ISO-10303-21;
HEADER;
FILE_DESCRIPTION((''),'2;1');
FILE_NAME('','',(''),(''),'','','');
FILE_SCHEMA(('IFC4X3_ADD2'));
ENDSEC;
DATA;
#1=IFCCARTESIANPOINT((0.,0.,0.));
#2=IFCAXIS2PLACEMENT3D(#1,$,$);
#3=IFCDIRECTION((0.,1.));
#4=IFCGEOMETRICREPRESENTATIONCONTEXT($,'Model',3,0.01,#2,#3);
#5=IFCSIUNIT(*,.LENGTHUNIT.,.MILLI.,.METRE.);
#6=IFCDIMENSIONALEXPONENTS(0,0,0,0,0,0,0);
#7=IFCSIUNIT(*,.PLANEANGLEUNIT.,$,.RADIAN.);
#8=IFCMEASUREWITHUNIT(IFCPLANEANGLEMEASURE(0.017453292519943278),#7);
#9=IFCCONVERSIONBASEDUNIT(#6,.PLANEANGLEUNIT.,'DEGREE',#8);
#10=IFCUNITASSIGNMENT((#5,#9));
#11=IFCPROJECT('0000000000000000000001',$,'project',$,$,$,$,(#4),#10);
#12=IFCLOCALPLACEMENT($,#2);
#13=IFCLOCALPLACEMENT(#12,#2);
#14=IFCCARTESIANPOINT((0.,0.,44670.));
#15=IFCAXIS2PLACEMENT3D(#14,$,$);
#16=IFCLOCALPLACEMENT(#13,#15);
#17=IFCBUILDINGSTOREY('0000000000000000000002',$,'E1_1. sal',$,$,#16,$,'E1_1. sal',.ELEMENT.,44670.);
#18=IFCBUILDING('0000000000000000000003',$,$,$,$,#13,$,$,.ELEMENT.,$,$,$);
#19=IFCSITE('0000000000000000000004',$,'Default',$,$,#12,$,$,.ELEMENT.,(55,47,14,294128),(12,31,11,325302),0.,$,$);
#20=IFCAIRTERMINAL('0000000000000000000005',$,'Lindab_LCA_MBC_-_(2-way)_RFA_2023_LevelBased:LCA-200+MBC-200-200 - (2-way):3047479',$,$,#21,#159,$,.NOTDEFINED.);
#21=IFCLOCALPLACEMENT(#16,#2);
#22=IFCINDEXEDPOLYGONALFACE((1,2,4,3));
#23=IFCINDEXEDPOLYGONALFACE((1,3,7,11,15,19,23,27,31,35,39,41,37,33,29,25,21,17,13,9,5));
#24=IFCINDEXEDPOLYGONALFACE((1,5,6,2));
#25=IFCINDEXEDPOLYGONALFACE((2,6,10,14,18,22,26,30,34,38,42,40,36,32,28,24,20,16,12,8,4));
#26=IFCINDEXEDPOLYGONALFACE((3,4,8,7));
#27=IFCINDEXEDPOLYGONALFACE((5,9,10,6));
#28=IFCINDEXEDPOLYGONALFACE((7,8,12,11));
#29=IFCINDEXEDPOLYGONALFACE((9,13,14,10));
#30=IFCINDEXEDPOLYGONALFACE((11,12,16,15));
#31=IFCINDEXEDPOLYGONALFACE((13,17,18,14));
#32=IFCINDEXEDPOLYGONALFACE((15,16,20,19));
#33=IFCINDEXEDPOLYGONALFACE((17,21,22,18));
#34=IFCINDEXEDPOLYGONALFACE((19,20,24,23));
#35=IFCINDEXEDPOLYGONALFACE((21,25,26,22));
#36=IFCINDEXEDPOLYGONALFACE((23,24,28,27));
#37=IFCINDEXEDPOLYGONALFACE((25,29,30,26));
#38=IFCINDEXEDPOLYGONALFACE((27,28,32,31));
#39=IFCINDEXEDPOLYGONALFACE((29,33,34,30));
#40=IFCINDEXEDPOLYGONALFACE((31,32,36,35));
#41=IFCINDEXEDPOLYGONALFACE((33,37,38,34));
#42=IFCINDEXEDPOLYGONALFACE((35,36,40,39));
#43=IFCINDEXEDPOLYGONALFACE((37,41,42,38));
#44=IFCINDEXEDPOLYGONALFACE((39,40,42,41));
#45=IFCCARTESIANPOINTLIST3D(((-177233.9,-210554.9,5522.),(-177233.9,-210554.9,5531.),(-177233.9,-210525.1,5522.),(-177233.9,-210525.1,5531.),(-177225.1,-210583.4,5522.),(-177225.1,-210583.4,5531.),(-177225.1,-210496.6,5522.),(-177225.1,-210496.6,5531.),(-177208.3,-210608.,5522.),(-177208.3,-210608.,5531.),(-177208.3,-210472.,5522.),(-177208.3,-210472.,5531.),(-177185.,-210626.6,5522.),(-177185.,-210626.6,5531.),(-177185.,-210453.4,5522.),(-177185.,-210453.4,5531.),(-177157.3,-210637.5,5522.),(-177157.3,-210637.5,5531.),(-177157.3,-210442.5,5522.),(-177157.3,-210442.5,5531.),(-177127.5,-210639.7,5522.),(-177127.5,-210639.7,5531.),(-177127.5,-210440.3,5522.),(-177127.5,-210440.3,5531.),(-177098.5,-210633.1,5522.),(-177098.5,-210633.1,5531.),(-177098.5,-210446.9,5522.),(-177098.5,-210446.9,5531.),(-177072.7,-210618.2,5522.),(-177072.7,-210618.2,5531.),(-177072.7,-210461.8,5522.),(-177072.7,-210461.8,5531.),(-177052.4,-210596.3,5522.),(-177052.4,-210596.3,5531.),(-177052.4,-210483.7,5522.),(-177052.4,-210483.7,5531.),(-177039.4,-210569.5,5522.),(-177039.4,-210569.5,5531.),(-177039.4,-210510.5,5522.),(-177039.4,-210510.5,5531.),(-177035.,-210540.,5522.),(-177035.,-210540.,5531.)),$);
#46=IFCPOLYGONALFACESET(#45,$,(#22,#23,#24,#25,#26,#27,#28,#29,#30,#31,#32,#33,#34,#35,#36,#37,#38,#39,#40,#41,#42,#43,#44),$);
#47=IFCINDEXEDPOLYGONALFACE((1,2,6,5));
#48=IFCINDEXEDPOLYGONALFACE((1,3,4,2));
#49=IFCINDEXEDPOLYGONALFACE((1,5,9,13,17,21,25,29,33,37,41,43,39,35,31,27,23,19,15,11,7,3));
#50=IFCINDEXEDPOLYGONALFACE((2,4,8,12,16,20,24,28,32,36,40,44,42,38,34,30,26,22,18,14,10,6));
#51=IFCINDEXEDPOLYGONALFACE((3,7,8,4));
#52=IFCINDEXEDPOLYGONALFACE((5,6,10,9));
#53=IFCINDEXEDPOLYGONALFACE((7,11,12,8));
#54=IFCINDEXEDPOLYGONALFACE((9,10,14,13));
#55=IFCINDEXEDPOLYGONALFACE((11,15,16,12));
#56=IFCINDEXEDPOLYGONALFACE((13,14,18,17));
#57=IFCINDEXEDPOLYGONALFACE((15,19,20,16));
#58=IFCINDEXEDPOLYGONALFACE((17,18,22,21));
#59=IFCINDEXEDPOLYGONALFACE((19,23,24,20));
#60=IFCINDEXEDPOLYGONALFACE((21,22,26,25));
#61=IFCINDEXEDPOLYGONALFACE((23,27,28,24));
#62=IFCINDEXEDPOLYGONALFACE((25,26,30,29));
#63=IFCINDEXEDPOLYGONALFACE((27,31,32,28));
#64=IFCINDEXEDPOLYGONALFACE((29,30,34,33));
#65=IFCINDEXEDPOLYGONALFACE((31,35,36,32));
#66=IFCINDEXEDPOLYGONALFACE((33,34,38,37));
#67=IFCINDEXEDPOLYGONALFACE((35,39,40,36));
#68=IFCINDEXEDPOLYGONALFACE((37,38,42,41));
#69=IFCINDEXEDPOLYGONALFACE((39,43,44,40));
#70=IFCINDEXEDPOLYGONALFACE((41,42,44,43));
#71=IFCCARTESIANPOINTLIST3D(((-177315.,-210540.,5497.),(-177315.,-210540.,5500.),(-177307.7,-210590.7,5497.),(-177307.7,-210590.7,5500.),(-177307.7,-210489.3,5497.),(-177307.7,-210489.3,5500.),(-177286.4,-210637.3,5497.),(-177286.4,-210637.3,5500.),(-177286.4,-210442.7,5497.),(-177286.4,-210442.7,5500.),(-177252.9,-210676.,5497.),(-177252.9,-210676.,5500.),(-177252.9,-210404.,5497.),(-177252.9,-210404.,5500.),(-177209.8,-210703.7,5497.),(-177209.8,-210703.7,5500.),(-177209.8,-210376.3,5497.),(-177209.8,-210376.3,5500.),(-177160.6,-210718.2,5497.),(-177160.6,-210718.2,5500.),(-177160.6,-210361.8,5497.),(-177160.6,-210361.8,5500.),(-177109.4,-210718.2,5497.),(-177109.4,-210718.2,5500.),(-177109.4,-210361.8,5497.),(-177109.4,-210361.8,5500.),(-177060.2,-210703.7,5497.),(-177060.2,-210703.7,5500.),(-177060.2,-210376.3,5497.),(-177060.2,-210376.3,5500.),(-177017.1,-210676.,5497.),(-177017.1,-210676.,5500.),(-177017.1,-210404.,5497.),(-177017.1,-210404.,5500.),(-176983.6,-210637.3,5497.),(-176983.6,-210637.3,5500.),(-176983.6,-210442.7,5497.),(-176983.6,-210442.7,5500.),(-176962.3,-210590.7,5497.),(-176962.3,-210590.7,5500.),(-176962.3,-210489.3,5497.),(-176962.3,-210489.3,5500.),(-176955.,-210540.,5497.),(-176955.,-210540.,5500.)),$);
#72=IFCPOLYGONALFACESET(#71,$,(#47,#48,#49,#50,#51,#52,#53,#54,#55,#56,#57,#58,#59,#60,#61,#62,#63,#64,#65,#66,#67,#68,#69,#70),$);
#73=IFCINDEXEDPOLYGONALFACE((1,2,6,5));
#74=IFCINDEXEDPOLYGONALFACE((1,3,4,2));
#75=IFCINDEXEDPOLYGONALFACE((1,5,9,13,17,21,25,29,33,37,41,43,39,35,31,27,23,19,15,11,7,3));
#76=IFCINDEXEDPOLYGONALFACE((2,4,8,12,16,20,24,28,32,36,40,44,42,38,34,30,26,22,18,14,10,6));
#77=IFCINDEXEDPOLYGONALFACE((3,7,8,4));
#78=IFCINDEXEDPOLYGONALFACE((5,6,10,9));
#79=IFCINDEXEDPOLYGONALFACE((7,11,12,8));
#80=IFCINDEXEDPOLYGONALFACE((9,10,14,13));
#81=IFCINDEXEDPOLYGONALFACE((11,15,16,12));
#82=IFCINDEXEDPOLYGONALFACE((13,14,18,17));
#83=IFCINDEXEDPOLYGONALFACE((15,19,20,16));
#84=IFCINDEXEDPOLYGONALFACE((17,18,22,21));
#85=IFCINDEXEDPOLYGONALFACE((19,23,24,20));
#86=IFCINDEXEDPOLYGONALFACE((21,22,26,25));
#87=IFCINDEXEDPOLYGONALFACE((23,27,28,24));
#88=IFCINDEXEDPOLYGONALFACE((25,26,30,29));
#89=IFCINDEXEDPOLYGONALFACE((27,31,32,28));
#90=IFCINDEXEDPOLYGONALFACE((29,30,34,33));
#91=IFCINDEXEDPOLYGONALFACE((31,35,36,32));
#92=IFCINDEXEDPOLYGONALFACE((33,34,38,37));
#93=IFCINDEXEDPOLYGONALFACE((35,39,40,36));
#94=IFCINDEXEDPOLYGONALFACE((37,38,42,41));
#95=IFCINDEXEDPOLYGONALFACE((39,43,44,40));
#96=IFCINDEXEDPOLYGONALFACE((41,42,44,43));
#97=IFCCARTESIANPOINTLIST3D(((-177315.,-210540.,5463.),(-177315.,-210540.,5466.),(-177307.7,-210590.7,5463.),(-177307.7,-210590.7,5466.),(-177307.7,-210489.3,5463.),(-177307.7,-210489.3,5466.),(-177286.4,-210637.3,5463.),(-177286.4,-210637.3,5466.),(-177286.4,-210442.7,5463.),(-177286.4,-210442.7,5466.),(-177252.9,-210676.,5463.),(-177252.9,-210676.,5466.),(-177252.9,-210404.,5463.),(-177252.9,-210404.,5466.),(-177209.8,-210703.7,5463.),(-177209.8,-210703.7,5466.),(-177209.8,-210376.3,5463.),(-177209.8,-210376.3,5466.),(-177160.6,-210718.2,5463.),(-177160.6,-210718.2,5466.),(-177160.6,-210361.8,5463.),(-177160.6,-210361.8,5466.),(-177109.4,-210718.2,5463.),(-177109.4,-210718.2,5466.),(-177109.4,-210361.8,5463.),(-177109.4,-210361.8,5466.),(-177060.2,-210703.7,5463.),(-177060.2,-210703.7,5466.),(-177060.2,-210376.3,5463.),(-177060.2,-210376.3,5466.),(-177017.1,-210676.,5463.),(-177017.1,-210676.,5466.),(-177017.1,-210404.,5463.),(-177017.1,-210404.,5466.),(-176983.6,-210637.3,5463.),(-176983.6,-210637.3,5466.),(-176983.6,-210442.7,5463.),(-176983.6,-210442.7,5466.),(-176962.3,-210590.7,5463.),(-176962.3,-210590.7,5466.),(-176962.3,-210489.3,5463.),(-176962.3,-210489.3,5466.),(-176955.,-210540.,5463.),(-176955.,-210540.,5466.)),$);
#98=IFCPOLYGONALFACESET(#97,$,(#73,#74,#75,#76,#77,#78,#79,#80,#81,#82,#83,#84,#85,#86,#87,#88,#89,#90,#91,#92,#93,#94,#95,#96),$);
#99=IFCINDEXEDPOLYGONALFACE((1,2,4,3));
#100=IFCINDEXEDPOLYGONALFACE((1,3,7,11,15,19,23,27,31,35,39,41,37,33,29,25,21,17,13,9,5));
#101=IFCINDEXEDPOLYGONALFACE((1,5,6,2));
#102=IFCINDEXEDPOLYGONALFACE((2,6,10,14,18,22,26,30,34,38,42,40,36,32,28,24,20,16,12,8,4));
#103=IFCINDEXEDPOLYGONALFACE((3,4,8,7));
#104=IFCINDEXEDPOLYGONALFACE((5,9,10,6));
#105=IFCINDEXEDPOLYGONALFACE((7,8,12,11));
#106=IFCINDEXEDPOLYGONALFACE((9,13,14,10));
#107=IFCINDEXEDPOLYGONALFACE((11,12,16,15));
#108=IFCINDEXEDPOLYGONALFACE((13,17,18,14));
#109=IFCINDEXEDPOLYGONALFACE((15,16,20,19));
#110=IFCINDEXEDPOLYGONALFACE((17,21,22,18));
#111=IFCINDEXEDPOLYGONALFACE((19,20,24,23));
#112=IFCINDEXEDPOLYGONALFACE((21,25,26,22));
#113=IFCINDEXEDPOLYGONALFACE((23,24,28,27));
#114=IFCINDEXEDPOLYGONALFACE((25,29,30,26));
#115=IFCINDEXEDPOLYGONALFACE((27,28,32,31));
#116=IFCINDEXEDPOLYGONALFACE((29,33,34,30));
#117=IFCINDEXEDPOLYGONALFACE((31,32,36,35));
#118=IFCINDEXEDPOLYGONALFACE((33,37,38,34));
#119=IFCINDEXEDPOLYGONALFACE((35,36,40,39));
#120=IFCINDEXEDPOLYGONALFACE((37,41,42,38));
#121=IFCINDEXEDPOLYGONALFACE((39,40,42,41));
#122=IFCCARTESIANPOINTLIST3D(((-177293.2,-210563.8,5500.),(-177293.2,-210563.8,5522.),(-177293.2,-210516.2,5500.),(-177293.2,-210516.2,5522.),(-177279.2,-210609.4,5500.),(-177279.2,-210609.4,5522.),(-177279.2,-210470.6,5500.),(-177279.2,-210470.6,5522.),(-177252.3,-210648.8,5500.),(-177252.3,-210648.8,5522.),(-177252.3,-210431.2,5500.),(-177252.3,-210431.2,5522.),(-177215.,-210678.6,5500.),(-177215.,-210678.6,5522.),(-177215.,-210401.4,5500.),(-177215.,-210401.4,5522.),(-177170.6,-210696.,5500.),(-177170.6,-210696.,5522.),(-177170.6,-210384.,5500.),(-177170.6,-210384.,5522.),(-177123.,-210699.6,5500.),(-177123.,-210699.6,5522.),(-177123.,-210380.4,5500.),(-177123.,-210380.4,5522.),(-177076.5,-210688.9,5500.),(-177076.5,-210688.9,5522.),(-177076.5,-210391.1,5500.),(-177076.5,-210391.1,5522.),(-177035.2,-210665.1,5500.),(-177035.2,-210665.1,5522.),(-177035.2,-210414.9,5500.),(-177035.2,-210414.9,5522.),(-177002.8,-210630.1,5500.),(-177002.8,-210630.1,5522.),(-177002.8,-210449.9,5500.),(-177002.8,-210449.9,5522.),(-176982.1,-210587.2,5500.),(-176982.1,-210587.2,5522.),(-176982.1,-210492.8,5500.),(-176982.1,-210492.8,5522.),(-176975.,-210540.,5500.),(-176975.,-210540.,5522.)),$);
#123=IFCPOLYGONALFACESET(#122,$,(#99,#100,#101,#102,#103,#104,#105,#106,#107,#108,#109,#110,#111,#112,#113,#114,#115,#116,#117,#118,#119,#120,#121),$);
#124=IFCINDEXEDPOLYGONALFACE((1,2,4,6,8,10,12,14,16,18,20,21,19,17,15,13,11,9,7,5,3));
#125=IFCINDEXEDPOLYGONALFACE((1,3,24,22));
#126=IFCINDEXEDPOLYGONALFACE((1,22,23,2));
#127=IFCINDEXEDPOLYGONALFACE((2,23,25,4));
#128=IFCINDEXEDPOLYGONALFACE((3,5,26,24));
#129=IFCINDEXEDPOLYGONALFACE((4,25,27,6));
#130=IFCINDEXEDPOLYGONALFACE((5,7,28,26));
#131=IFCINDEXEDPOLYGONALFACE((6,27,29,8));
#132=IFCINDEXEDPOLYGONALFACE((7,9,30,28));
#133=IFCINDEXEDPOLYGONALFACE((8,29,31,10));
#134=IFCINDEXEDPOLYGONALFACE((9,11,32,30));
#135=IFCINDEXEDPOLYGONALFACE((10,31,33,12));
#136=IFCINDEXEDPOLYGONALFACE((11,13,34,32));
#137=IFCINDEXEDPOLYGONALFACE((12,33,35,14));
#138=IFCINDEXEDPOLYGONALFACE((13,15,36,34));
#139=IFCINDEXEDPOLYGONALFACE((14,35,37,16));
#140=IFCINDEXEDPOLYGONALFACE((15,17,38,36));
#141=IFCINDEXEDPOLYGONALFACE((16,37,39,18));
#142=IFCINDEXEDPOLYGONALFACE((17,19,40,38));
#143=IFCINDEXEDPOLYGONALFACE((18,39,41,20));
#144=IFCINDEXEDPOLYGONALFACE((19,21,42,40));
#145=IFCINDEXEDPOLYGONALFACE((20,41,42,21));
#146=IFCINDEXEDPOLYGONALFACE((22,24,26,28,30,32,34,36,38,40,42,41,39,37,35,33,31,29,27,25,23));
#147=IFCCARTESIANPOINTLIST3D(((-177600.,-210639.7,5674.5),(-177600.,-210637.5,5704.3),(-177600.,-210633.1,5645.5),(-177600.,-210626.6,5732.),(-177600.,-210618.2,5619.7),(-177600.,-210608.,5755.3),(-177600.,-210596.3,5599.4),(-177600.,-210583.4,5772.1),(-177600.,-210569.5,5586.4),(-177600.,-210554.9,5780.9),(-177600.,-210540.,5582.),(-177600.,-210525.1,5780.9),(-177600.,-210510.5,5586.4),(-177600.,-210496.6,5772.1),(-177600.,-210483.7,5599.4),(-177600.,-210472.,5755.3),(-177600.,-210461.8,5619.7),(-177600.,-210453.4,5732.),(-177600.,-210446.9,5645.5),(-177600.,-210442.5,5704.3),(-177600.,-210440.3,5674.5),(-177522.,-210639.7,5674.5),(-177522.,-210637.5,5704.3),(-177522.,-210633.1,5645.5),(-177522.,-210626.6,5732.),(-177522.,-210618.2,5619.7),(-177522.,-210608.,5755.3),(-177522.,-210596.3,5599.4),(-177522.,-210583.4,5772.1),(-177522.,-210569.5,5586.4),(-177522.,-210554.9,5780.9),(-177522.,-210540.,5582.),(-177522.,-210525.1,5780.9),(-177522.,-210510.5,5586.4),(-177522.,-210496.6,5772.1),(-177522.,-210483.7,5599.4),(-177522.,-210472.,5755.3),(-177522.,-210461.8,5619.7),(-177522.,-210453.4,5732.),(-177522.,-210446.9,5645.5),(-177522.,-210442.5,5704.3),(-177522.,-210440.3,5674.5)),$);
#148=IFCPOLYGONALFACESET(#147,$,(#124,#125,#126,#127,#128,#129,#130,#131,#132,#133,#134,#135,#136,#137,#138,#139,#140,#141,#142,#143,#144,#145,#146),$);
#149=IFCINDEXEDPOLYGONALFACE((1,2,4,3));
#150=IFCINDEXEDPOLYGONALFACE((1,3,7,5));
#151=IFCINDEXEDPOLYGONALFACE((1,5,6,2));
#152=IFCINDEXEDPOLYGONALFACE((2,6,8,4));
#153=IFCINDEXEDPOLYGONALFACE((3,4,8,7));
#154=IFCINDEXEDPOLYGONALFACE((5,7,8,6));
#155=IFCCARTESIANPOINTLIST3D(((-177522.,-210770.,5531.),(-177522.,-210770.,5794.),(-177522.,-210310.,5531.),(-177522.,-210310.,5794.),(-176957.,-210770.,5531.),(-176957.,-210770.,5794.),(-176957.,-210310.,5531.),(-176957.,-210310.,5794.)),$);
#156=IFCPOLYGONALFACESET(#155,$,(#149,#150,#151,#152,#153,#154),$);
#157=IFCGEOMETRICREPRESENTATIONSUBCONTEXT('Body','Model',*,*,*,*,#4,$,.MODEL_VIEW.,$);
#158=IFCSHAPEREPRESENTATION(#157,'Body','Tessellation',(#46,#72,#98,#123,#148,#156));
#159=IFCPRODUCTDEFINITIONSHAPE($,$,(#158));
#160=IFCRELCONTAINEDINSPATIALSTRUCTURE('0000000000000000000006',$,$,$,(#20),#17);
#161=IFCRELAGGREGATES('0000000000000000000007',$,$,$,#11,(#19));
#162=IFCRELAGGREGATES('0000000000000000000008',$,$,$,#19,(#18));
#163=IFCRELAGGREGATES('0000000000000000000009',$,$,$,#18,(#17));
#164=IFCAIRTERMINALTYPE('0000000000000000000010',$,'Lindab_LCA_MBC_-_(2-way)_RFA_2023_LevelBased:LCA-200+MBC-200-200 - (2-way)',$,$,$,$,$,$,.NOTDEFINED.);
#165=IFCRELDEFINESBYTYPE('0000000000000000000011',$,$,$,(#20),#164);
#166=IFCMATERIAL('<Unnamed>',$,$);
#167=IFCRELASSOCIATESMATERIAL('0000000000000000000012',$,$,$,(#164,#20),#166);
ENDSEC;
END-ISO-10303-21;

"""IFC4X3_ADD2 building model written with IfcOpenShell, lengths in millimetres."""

from ifc_helpers import new_model, entity, si_unit, converted_unit, direction, frame, frame_2d, origin, origin_2d_with_axis, place, context, subcontext, project, spatial, rectangle, circle, extrude, source, transform, mapped, material, type_object, type_shapes, element, save


model = new_model("IFC4X3_ADD2")

# Units and contexts
model_context = context("Model", 3, precision=0.01, world=origin(), true_north=direction((0.0, 1.0)))
body_context = subcontext(model_context, "Body", "Model", "MODEL_VIEW")
ifc_project = project(units=[si_unit("LENGTHUNIT", "METRE", prefix="MILLI"), converted_unit("PLANEANGLEUNIT", "DEGREE", entity("IfcPlaneAngleMeasure", 0.017453292519943278), si_unit("PLANEANGLEUNIT", "RADIAN"), dimensions=[0, 0, 0, 0, 0, 0, 0])], contexts=[model_context])

# Site, building, storey
site_placement = place(None, origin())
site = spatial("IfcSite", under=ifc_project, at=site_placement, Name="Default", CompositionType="ELEMENT", RefLatitude=(55, 47, 14, 294128), RefLongitude=(12, 31, 11, 325302), RefElevation=0.0)
building_placement = place(site_placement, origin())
building = spatial("IfcBuilding", under=site, at=building_placement, CompositionType="ELEMENT")
storey_placement = place(building_placement, frame((0.0, 0.0, 44670.0)))
storey = spatial("IfcBuildingStorey", under=building, at=storey_placement, Name="E1_1. sal", LongName="E1_1. sal", CompositionType="ELEMENT", Elevation=44670.0)

# Air terminal
ifc_material_1 = material(Name="<Unnamed>")
air_terminal_type_1 = type_object("IfcAirTerminalType", Name="Lindab_LCA_MBC_-_(2-way)_RFA_2023_LevelBased:LCA-200+MBC-200-200 - (2-way)", PredefinedType="NOTDEFINED", material=ifc_material_1)
shared_shape_1 = source(origin(), body_context, "Body", "SweptSolid", [
    extrude(circle(Radius=100.0, at=frame_2d((0.0, 0.0), x_axis=(1.0, 0.0))), frame((0.0, 0.0, 22.0)), (0.0, 0.0, 1.0), 9.0),
    extrude(circle(Radius=180.0, at=frame_2d((0.0, 0.0), x_axis=(1.0, 0.0))), frame((0.0, 0.0, -3.0)), (0.0, 0.0, 1.0), 3.0),
    extrude(circle(Radius=180.0, at=frame_2d((0.0, 0.0), x_axis=(1.0, 0.0))), frame((0.0, 0.0, -37.0)), (0.0, 0.0, 1.0), 3.0),
    extrude(circle(Radius=160.0, at=frame_2d((0.0, 0.0), x_axis=(1.0, 0.0))), origin(), (0.0, 0.0, 1.0), 22.0),
    extrude(circle(Radius=100.0, at=frame_2d((0.0, 0.0), x_axis=(1.0, 0.0))), frame((-465.0, 0.0, 182.0), z_axis=(1.0, 0.0, 0.0), x_axis=(0.0, 0.0, -1.0)), (0.0, 0.0, 1.0), 78.0),
    extrude(rectangle(XDim=460.0, YDim=565.0, at=origin_2d_with_axis()), frame((-104.5, 0.0, 31.0), z_axis=(0.0, 0.0, 1.0), x_axis=(0.0, -1.0, 0.0)), (0.0, 0.0, 1.0), 263.0),
])
type_shapes(air_terminal_type_1, [shared_shape_1])
for number, where, name in (
    (1, (-177135.0, -210540.0, 5500.0), "Lindab_LCA_MBC_-_(2-way)_RFA_2023_LevelBased:LCA-200+MBC-200-200 - (2-way):3047479"),
):
    element("IfcAirTerminal", number, at=place(storey_placement, frame(where)), inside=storey, type_object=air_terminal_type_1, material=ifc_material_1, Name=name, PredefinedType="NOTDEFINED", context=body_context, shape_type="MappedRepresentation", body=[
        mapped(shared_shape_1, transform((0.0, 0.0, 0.0), scale=1.0)),
    ])

save(model, "model.ifc")
